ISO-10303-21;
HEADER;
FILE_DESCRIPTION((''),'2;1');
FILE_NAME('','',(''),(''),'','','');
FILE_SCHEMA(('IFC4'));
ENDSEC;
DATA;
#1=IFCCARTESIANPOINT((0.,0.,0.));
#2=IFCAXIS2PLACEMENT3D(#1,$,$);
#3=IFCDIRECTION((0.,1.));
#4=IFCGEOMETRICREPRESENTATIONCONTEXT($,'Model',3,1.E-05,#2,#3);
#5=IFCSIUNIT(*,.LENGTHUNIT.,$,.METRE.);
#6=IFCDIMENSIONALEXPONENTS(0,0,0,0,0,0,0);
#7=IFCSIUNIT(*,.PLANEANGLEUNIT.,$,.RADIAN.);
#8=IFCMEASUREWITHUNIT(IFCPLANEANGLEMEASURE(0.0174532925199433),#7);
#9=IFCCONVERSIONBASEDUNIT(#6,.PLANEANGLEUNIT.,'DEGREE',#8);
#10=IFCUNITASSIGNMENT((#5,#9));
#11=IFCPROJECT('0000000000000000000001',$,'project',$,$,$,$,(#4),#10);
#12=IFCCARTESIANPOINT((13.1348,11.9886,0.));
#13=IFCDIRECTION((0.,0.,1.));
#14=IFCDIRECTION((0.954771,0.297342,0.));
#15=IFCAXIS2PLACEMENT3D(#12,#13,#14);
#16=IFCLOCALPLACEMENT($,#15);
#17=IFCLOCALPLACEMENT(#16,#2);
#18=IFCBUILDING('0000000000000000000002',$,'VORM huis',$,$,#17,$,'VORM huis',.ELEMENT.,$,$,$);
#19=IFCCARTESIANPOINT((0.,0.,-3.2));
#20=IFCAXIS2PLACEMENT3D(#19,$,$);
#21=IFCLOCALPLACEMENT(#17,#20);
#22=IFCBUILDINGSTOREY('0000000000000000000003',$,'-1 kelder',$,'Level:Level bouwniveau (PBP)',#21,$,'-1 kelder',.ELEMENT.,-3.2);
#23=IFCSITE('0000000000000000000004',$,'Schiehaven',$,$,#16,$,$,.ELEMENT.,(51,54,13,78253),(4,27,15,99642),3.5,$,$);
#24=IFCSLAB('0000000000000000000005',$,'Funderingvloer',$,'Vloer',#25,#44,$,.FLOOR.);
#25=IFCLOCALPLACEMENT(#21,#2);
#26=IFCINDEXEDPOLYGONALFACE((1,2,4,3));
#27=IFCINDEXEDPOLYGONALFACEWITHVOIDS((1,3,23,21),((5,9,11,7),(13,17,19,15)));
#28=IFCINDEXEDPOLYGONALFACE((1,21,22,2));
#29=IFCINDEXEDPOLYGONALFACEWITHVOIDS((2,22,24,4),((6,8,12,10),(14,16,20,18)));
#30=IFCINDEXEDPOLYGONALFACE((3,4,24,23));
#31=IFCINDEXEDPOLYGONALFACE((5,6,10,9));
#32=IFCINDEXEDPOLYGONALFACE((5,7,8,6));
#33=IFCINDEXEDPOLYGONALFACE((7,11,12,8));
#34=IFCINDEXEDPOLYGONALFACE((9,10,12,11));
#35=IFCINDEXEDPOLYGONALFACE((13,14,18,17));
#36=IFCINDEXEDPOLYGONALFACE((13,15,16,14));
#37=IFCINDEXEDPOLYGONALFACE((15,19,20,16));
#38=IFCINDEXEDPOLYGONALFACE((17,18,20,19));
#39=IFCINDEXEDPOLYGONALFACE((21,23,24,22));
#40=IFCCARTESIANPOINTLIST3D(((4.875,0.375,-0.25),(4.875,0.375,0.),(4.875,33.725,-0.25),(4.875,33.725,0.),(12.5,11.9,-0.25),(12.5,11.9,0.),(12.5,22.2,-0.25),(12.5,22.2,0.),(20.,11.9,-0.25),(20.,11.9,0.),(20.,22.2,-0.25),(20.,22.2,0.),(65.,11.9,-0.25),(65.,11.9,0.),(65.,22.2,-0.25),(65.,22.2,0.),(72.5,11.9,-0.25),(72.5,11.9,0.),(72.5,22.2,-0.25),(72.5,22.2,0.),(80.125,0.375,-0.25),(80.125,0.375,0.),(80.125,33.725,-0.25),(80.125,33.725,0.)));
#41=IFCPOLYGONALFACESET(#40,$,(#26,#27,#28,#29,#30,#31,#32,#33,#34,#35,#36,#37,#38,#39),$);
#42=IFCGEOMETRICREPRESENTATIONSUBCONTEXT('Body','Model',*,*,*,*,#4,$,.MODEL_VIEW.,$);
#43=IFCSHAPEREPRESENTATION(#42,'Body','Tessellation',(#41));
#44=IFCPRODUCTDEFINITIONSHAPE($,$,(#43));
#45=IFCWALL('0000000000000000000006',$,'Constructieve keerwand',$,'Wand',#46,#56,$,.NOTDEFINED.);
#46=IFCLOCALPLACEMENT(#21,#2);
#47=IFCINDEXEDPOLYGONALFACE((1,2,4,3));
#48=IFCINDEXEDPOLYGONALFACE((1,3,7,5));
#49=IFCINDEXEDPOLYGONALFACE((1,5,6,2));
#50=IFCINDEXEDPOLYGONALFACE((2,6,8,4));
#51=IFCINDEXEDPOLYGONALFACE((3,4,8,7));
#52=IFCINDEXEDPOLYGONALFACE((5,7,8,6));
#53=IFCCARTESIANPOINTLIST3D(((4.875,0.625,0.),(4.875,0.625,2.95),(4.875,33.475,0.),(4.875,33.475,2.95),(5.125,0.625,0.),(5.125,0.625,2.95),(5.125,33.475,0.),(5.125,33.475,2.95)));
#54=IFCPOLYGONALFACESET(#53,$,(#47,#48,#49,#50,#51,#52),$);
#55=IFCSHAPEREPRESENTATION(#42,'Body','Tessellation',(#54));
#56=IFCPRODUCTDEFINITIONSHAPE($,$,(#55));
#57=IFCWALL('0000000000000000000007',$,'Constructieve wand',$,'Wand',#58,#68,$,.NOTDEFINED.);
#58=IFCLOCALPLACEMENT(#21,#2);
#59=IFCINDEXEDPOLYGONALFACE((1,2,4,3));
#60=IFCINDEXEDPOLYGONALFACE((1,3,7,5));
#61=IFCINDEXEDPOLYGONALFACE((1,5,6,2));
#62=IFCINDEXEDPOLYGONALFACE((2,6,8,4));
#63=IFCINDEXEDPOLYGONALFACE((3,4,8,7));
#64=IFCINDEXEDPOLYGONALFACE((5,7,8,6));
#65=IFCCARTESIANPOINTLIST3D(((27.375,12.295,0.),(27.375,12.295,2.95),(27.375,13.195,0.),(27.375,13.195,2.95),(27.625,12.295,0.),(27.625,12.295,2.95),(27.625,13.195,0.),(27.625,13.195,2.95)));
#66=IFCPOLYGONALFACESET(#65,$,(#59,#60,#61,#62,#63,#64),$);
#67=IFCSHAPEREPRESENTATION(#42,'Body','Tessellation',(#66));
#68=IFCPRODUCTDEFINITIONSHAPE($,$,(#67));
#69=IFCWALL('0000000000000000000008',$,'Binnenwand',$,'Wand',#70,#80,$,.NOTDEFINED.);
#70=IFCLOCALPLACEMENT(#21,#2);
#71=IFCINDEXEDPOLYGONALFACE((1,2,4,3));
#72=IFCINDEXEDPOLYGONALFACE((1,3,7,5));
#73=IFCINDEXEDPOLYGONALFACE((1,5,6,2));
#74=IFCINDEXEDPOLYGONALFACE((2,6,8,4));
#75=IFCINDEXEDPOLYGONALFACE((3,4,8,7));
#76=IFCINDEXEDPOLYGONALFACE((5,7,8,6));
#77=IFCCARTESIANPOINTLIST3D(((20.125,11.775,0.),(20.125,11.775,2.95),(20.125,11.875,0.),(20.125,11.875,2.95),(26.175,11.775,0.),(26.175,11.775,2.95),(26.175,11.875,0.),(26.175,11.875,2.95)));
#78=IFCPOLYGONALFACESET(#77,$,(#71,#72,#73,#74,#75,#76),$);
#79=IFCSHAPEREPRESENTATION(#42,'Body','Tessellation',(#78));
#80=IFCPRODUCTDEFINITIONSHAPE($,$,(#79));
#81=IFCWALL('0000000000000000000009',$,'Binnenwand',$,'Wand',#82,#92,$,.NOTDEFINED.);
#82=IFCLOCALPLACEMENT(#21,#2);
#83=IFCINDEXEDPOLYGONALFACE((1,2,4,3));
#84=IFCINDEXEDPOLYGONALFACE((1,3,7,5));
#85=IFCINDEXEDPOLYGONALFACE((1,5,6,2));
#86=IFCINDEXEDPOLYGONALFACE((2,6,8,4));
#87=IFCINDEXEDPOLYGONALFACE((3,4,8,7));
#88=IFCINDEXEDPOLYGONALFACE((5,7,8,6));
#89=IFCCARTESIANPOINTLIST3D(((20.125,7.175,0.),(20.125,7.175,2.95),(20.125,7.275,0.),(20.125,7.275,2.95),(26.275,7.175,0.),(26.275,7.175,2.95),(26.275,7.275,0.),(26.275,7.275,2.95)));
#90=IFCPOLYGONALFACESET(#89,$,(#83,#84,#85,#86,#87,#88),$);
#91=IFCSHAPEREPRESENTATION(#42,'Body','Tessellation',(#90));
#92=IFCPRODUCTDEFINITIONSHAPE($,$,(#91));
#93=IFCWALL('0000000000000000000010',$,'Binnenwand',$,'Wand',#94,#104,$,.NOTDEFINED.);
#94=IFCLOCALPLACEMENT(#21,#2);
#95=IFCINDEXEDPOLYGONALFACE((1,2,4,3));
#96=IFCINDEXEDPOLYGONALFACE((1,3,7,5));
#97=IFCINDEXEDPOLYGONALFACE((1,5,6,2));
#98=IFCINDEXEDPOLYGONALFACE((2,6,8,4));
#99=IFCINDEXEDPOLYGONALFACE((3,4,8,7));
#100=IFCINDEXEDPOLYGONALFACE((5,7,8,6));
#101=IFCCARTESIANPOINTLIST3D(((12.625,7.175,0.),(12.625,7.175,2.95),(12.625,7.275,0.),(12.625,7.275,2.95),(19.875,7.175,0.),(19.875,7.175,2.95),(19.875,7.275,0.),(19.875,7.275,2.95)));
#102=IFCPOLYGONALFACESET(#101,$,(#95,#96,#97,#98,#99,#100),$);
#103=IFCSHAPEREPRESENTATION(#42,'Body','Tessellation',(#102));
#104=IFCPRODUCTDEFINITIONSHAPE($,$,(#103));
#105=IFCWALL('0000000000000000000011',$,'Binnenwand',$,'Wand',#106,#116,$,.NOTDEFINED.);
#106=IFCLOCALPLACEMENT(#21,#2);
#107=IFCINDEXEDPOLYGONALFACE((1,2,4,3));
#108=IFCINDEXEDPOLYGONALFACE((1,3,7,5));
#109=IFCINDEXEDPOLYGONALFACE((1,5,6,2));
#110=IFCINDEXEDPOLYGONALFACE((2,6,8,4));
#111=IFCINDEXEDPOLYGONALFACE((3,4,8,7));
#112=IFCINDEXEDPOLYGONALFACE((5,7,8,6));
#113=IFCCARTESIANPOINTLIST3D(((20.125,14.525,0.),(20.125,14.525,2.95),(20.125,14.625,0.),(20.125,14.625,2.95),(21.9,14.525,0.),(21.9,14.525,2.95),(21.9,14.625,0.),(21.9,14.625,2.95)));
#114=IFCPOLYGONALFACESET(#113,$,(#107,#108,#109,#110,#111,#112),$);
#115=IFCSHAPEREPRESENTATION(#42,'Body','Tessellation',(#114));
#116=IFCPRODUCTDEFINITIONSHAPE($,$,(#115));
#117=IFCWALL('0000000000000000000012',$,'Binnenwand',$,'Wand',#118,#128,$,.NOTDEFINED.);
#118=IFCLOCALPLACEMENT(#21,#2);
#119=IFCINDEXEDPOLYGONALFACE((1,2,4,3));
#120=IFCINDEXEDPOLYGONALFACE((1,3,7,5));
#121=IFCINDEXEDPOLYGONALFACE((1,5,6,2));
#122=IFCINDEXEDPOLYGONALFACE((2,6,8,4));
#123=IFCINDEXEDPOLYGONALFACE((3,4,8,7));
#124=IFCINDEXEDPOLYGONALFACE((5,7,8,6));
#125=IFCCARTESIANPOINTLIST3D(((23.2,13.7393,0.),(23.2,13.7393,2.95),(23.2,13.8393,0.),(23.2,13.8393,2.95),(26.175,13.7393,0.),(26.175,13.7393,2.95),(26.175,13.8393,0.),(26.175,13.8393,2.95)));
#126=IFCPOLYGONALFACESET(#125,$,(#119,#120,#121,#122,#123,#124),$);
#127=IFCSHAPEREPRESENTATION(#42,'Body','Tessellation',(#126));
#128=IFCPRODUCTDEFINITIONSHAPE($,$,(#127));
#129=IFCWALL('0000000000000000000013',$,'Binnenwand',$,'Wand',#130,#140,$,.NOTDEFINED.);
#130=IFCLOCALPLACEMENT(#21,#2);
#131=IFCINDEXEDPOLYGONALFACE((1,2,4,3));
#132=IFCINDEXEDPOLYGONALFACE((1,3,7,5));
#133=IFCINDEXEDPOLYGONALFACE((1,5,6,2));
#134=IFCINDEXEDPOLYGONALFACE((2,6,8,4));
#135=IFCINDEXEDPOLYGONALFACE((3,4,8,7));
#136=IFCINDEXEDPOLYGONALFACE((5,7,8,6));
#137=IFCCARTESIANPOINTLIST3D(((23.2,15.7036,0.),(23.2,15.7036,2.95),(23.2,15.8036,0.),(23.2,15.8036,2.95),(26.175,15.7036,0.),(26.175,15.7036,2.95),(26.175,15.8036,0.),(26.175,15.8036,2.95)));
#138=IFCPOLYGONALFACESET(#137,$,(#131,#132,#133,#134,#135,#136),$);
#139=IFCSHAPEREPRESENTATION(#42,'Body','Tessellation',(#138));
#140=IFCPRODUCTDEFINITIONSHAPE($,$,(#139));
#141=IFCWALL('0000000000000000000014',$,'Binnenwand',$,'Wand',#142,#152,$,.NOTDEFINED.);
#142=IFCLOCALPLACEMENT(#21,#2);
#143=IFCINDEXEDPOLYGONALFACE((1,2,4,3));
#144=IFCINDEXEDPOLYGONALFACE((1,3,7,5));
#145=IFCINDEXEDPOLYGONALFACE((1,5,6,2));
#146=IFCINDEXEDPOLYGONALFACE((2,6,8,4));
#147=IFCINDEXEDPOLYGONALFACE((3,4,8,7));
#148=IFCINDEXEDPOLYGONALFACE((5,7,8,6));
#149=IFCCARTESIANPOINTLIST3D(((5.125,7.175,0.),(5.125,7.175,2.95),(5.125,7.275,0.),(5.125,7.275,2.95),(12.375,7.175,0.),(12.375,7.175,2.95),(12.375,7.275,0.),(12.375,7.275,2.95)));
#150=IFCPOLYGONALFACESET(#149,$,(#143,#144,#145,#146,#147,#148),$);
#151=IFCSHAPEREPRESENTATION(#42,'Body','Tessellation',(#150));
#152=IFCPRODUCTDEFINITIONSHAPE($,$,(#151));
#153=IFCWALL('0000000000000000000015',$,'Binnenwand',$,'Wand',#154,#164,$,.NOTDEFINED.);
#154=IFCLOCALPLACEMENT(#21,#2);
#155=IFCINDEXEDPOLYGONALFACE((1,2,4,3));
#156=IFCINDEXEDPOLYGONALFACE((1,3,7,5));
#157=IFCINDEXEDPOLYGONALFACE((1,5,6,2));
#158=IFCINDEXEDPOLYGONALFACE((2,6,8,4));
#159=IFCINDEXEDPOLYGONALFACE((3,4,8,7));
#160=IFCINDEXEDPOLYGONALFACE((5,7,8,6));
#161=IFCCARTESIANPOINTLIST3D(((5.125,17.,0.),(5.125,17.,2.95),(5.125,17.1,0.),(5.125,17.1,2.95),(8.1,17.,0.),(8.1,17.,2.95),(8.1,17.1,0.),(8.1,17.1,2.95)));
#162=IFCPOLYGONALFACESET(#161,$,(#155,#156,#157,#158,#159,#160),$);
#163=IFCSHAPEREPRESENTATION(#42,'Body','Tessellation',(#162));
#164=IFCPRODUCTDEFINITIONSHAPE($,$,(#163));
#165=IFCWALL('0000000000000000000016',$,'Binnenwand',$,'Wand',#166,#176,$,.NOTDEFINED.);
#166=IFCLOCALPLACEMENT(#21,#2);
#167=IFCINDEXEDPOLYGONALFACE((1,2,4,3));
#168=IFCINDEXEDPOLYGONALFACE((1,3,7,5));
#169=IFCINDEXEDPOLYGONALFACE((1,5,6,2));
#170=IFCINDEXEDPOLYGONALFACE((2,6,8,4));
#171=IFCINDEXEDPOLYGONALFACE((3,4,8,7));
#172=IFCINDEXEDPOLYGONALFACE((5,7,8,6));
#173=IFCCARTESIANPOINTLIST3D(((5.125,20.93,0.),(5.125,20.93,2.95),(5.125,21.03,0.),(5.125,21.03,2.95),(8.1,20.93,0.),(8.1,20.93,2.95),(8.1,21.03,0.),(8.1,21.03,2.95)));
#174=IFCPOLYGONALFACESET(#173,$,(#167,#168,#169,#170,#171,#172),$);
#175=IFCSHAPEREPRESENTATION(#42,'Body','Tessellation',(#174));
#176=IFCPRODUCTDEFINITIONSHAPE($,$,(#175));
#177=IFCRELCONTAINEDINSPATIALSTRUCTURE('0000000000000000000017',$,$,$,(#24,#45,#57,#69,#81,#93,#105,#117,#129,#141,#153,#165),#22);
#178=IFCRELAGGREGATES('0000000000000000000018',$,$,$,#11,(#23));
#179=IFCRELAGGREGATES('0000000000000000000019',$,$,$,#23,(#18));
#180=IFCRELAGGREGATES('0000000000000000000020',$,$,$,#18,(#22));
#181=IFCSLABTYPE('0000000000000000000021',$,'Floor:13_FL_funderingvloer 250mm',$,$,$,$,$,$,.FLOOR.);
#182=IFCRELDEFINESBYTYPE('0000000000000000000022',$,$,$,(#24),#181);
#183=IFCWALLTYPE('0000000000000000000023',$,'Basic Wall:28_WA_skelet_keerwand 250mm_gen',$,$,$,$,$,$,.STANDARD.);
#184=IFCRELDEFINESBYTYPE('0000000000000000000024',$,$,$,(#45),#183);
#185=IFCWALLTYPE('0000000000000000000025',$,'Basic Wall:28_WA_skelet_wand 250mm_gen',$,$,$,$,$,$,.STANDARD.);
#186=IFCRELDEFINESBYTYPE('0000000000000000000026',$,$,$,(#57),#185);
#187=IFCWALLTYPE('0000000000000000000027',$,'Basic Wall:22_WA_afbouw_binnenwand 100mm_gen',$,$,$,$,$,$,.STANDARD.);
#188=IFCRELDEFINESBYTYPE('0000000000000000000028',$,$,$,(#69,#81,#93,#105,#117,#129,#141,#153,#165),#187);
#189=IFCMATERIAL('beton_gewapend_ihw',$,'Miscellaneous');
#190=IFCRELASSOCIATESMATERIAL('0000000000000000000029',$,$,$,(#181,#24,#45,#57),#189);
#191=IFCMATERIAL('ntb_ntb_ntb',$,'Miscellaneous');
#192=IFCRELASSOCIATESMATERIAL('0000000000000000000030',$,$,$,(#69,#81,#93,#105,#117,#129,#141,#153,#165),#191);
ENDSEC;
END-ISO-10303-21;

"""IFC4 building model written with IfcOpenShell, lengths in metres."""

from ifc_helpers import new_model, entity, si_unit, converted_unit, direction, frame, origin, place, context, subcontext, project, spatial, indexed_curve, outline, extrude, material, type_object, element, save


model = new_model("IFC4")

# Units and contexts
model_context = context("Model", 3, precision=1e-05, world=origin(), true_north=direction((0.0, 1.0)))
body_context = subcontext(model_context, "Body", "Model", "MODEL_VIEW")
ifc_project = project(units=[si_unit("LENGTHUNIT", "METRE"), converted_unit("PLANEANGLEUNIT", "DEGREE", entity("IfcPlaneAngleMeasure", 0.0174532925199433), si_unit("PLANEANGLEUNIT", "RADIAN"), dimensions=[0, 0, 0, 0, 0, 0, 0])], contexts=[model_context])

# Site, building, storey
site_placement = place(None, frame((13.1348, 11.9886, 0.0), z_axis=(0.0, 0.0, 1.0), x_axis=(0.954771, 0.297342, 0.0)))
site = spatial("IfcSite", under=ifc_project, at=site_placement, Name="Schiehaven", CompositionType="ELEMENT", RefLatitude=(51, 54, 13, 78253), RefLongitude=(4, 27, 15, 99642), RefElevation=3.5)
building_placement = place(site_placement, origin())
building = spatial("IfcBuilding", under=site, at=building_placement, Name="VORM huis", LongName="VORM huis", CompositionType="ELEMENT")
storey_placement = place(building_placement, frame((0.0, 0.0, -3.2)))
storey = spatial("IfcBuildingStorey", under=building, at=storey_placement, Name="-1 kelder", ObjectType="Level:Level bouwniveau (PBP)", LongName="-1 kelder", CompositionType="ELEMENT", Elevation=-3.2)

# Slab, openings
ifc_material_1 = material(Name="beton_gewapend_ihw", Category="Miscellaneous")
slab_type = type_object("IfcSlabType", Name="Floor:13_FL_funderingvloer 250mm", PredefinedType="FLOOR", material=ifc_material_1)
slab_placement = place(storey_placement, origin())
slab = element("IfcSlab", 1, at=slab_placement, inside=storey, type_object=slab_type, material=ifc_material_1, Name="Funderingvloer", ObjectType="Vloer", PredefinedType="FLOOR", context=body_context, shape_type="SweptSolid", body=[
    extrude(outline(indexed_curve([(-37.625, -16.675), (37.625, -16.675), (37.625, 16.675), (-37.625, 16.675), (-37.625, -16.675)], self_intersect=False), holes=[indexed_curve([(22.5, -5.15), (22.5, 5.15), (30.0, 5.15), (30.0, -5.15), (22.5, -5.15)], self_intersect=False), indexed_curve([(-30.0, -5.15), (-30.0, 5.15), (-22.5, 5.15), (-22.5, -5.15), (-30.0, -5.15)], self_intersect=False)]), frame((42.5, 17.05, -0.25), z_axis=(0.0, 0.0, 1.0), x_axis=(-1.0, 0.0, 0.0)), (0.0, 0.0, 1.0), 0.25),
])
opening_1_placement = place(slab_placement, origin())
element("IfcOpeningElement", 2, at=opening_1_placement, cuts=slab, PredefinedType="OPENING", context=body_context, shape_type="SweptSolid", body=[
    extrude(outline(indexed_curve([(-5.15, -3.75), (5.15, -3.75), (5.15, 3.75), (-5.15, 3.75), (-5.15, -3.75)], self_intersect=False)), frame((16.25, 17.05, 0.0), z_axis=(0.0, 0.0, -1.0), x_axis=(0.0, -1.0, 0.0)), (0.0, 0.0, 1.0), 33.35),
])
opening_2_placement = place(slab_placement, origin())
element("IfcOpeningElement", 3, at=opening_2_placement, cuts=slab, PredefinedType="OPENING", context=body_context, shape_type="SweptSolid", body=[
    extrude(outline(indexed_curve([(-5.15, -3.75), (5.15, -3.75), (5.15, 3.75), (-5.15, 3.75), (-5.15, -3.75)], self_intersect=False)), frame((68.75, 17.05, 0.0), z_axis=(0.0, 0.0, -1.0), x_axis=(0.0, -1.0, 0.0)), (0.0, 0.0, 1.0), 33.35),
])

# Walls
wall_type_1 = type_object("IfcWallType", Name="Basic Wall:28_WA_skelet_keerwand 250mm_gen", PredefinedType="STANDARD")
wall_1_placement = place(storey_placement, frame((5.0, 0.625, 0.0), z_axis=(0.0, 0.0, 1.0), x_axis=(0.0, 1.0, 0.0)))
element("IfcWall", 4, at=wall_1_placement, inside=storey, type_object=wall_type_1, material=ifc_material_1, Name="Constructieve keerwand", ObjectType="Wand", PredefinedType="NOTDEFINED", context=body_context, shape_type="SweptSolid", body=[
    extrude(outline(indexed_curve([(32.85, 0.125), (0.0, 0.125), (0.0, -0.125), (32.85, -0.125), (32.85, 0.125)], self_intersect=False)), origin(), (0.0, 0.0, 1.0), 2.95),
])
wall_type_2 = type_object("IfcWallType", Name="Basic Wall:28_WA_skelet_wand 250mm_gen", PredefinedType="STANDARD")
wall_2_placement = place(storey_placement, frame((27.5, 12.295, 0.0), z_axis=(0.0, 0.0, 1.0), x_axis=(0.0, 1.0, 0.0)))
element("IfcWall", 5, at=wall_2_placement, inside=storey, type_object=wall_type_2, material=ifc_material_1, Name="Constructieve wand", ObjectType="Wand", PredefinedType="NOTDEFINED", context=body_context, shape_type="SweptSolid", body=[
    extrude(outline(indexed_curve([(0.9, 0.125), (0.0, 0.125), (0.0, -0.125), (0.9, -0.125), (0.9, 0.125)], self_intersect=False)), origin(), (0.0, 0.0, 1.0), 2.95),
])
ifc_material_2 = material(Name="ntb_ntb_ntb", Category="Miscellaneous")
wall_type_3 = type_object("IfcWallType", Name="Basic Wall:22_WA_afbouw_binnenwand 100mm_gen", PredefinedType="STANDARD")
wall_3_placement = place(storey_placement, frame((26.175, 11.825, 0.0), z_axis=(0.0, 0.0, 1.0), x_axis=(-1.0, 0.0, 0.0)))
element("IfcWall", 6, at=wall_3_placement, inside=storey, type_object=wall_type_3, material=ifc_material_2, Name="Binnenwand", ObjectType="Wand", PredefinedType="NOTDEFINED", context=body_context, shape_type="SweptSolid", body=[
    extrude(outline(indexed_curve([(6.05, 0.05), (0.0, 0.05), (0.0, -0.05), (6.05, -0.05), (6.05, 0.05)], self_intersect=False)), origin(), (0.0, 0.0, 1.0), 2.95),
])
wall_4_placement = place(storey_placement, frame((26.275, 7.225, 0.0), z_axis=(0.0, 0.0, 1.0), x_axis=(-1.0, 0.0, 0.0)))
element("IfcWall", 7, at=wall_4_placement, inside=storey, type_object=wall_type_3, material=ifc_material_2, Name="Binnenwand", ObjectType="Wand", PredefinedType="NOTDEFINED", context=body_context, shape_type="SweptSolid", body=[
    extrude(outline(indexed_curve([(6.15, 0.05), (0.0, 0.05), (0.0, -0.05), (6.15, -0.05), (6.15, 0.05)], self_intersect=False)), origin(), (0.0, 0.0, 1.0), 2.95),
])
wall_5_placement = place(storey_placement, frame((12.625, 7.225, 0.0)))
element("IfcWall", 8, at=wall_5_placement, inside=storey, type_object=wall_type_3, material=ifc_material_2, Name="Binnenwand", ObjectType="Wand", PredefinedType="NOTDEFINED", context=body_context, shape_type="SweptSolid", body=[
    extrude(outline(indexed_curve([(7.25, 0.05), (0.0, 0.05), (0.0, -0.05), (7.25, -0.05), (7.25, 0.05)], self_intersect=False)), origin(), (0.0, 0.0, 1.0), 2.95),
])
wall_6_placement = place(storey_placement, frame((21.9, 14.575, 0.0), z_axis=(0.0, 0.0, 1.0), x_axis=(-1.0, 0.0, 0.0)))
element("IfcWall", 9, at=wall_6_placement, inside=storey, type_object=wall_type_3, material=ifc_material_2, Name="Binnenwand", ObjectType="Wand", PredefinedType="NOTDEFINED", context=body_context, shape_type="SweptSolid", body=[
    extrude(outline(indexed_curve([(1.775, 0.05), (0.0, 0.05), (0.0, -0.05), (1.775, -0.05), (1.775, 0.05)], self_intersect=False)), origin(), (0.0, 0.0, 1.0), 2.95),
])
for number, where, name in (
    (10, (23.2, 13.7893, 0.0), "Binnenwand"),
    (11, (23.2, 15.7536, 0.0), "Binnenwand"),
):
    element("IfcWall", number, at=place(storey_placement, frame(where)), inside=storey, type_object=wall_type_3, material=ifc_material_2, Name=name, ObjectType="Wand", PredefinedType="NOTDEFINED", context=body_context, shape_type="SweptSolid", body=[
        extrude(outline(indexed_curve([(2.975, 0.05), (0.0, 0.05), (0.0, -0.05), (2.975, -0.05), (2.975, 0.05)], self_intersect=False)), origin(), (0.0, 0.0, 1.0), 2.95),
    ])
wall_7_placement = place(storey_placement, frame((5.125, 7.225, 0.0)))
element("IfcWall", 12, at=wall_7_placement, inside=storey, type_object=wall_type_3, material=ifc_material_2, Name="Binnenwand", ObjectType="Wand", PredefinedType="NOTDEFINED", context=body_context, shape_type="SweptSolid", body=[
    extrude(outline(indexed_curve([(7.25, 0.05), (0.0, 0.05), (0.0, -0.05), (7.25, -0.05), (7.25, 0.05)], self_intersect=False)), origin(), (0.0, 0.0, 1.0), 2.95),
])
wall_8_placement = place(storey_placement, frame((8.1, 17.05, 0.0), z_axis=(0.0, 0.0, 1.0), x_axis=(-1.0, 0.0, 0.0)))
element("IfcWall", 13, at=wall_8_placement, inside=storey, type_object=wall_type_3, material=ifc_material_2, Name="Binnenwand", ObjectType="Wand", PredefinedType="NOTDEFINED", context=body_context, shape_type="SweptSolid", body=[
    extrude(outline(indexed_curve([(2.975, 0.05), (0.0, 0.05), (0.0, -0.05), (2.975, -0.05), (2.975, 0.05)], self_intersect=False)), origin(), (0.0, 0.0, 1.0), 2.95),
])
wall_9_placement = place(storey_placement, frame((8.1, 20.98, 0.0), z_axis=(0.0, 0.0, 1.0), x_axis=(-1.0, 0.0, 0.0)))
element("IfcWall", 14, at=wall_9_placement, inside=storey, type_object=wall_type_3, material=ifc_material_2, Name="Binnenwand", ObjectType="Wand", PredefinedType="NOTDEFINED", context=body_context, shape_type="SweptSolid", body=[
    extrude(outline(indexed_curve([(2.975, 0.05), (0.0, 0.05), (0.0, -0.05), (2.975, -0.05), (2.975, 0.05)], self_intersect=False)), origin(), (0.0, 0.0, 1.0), 2.95),
])

save(model, "model.ifc")
